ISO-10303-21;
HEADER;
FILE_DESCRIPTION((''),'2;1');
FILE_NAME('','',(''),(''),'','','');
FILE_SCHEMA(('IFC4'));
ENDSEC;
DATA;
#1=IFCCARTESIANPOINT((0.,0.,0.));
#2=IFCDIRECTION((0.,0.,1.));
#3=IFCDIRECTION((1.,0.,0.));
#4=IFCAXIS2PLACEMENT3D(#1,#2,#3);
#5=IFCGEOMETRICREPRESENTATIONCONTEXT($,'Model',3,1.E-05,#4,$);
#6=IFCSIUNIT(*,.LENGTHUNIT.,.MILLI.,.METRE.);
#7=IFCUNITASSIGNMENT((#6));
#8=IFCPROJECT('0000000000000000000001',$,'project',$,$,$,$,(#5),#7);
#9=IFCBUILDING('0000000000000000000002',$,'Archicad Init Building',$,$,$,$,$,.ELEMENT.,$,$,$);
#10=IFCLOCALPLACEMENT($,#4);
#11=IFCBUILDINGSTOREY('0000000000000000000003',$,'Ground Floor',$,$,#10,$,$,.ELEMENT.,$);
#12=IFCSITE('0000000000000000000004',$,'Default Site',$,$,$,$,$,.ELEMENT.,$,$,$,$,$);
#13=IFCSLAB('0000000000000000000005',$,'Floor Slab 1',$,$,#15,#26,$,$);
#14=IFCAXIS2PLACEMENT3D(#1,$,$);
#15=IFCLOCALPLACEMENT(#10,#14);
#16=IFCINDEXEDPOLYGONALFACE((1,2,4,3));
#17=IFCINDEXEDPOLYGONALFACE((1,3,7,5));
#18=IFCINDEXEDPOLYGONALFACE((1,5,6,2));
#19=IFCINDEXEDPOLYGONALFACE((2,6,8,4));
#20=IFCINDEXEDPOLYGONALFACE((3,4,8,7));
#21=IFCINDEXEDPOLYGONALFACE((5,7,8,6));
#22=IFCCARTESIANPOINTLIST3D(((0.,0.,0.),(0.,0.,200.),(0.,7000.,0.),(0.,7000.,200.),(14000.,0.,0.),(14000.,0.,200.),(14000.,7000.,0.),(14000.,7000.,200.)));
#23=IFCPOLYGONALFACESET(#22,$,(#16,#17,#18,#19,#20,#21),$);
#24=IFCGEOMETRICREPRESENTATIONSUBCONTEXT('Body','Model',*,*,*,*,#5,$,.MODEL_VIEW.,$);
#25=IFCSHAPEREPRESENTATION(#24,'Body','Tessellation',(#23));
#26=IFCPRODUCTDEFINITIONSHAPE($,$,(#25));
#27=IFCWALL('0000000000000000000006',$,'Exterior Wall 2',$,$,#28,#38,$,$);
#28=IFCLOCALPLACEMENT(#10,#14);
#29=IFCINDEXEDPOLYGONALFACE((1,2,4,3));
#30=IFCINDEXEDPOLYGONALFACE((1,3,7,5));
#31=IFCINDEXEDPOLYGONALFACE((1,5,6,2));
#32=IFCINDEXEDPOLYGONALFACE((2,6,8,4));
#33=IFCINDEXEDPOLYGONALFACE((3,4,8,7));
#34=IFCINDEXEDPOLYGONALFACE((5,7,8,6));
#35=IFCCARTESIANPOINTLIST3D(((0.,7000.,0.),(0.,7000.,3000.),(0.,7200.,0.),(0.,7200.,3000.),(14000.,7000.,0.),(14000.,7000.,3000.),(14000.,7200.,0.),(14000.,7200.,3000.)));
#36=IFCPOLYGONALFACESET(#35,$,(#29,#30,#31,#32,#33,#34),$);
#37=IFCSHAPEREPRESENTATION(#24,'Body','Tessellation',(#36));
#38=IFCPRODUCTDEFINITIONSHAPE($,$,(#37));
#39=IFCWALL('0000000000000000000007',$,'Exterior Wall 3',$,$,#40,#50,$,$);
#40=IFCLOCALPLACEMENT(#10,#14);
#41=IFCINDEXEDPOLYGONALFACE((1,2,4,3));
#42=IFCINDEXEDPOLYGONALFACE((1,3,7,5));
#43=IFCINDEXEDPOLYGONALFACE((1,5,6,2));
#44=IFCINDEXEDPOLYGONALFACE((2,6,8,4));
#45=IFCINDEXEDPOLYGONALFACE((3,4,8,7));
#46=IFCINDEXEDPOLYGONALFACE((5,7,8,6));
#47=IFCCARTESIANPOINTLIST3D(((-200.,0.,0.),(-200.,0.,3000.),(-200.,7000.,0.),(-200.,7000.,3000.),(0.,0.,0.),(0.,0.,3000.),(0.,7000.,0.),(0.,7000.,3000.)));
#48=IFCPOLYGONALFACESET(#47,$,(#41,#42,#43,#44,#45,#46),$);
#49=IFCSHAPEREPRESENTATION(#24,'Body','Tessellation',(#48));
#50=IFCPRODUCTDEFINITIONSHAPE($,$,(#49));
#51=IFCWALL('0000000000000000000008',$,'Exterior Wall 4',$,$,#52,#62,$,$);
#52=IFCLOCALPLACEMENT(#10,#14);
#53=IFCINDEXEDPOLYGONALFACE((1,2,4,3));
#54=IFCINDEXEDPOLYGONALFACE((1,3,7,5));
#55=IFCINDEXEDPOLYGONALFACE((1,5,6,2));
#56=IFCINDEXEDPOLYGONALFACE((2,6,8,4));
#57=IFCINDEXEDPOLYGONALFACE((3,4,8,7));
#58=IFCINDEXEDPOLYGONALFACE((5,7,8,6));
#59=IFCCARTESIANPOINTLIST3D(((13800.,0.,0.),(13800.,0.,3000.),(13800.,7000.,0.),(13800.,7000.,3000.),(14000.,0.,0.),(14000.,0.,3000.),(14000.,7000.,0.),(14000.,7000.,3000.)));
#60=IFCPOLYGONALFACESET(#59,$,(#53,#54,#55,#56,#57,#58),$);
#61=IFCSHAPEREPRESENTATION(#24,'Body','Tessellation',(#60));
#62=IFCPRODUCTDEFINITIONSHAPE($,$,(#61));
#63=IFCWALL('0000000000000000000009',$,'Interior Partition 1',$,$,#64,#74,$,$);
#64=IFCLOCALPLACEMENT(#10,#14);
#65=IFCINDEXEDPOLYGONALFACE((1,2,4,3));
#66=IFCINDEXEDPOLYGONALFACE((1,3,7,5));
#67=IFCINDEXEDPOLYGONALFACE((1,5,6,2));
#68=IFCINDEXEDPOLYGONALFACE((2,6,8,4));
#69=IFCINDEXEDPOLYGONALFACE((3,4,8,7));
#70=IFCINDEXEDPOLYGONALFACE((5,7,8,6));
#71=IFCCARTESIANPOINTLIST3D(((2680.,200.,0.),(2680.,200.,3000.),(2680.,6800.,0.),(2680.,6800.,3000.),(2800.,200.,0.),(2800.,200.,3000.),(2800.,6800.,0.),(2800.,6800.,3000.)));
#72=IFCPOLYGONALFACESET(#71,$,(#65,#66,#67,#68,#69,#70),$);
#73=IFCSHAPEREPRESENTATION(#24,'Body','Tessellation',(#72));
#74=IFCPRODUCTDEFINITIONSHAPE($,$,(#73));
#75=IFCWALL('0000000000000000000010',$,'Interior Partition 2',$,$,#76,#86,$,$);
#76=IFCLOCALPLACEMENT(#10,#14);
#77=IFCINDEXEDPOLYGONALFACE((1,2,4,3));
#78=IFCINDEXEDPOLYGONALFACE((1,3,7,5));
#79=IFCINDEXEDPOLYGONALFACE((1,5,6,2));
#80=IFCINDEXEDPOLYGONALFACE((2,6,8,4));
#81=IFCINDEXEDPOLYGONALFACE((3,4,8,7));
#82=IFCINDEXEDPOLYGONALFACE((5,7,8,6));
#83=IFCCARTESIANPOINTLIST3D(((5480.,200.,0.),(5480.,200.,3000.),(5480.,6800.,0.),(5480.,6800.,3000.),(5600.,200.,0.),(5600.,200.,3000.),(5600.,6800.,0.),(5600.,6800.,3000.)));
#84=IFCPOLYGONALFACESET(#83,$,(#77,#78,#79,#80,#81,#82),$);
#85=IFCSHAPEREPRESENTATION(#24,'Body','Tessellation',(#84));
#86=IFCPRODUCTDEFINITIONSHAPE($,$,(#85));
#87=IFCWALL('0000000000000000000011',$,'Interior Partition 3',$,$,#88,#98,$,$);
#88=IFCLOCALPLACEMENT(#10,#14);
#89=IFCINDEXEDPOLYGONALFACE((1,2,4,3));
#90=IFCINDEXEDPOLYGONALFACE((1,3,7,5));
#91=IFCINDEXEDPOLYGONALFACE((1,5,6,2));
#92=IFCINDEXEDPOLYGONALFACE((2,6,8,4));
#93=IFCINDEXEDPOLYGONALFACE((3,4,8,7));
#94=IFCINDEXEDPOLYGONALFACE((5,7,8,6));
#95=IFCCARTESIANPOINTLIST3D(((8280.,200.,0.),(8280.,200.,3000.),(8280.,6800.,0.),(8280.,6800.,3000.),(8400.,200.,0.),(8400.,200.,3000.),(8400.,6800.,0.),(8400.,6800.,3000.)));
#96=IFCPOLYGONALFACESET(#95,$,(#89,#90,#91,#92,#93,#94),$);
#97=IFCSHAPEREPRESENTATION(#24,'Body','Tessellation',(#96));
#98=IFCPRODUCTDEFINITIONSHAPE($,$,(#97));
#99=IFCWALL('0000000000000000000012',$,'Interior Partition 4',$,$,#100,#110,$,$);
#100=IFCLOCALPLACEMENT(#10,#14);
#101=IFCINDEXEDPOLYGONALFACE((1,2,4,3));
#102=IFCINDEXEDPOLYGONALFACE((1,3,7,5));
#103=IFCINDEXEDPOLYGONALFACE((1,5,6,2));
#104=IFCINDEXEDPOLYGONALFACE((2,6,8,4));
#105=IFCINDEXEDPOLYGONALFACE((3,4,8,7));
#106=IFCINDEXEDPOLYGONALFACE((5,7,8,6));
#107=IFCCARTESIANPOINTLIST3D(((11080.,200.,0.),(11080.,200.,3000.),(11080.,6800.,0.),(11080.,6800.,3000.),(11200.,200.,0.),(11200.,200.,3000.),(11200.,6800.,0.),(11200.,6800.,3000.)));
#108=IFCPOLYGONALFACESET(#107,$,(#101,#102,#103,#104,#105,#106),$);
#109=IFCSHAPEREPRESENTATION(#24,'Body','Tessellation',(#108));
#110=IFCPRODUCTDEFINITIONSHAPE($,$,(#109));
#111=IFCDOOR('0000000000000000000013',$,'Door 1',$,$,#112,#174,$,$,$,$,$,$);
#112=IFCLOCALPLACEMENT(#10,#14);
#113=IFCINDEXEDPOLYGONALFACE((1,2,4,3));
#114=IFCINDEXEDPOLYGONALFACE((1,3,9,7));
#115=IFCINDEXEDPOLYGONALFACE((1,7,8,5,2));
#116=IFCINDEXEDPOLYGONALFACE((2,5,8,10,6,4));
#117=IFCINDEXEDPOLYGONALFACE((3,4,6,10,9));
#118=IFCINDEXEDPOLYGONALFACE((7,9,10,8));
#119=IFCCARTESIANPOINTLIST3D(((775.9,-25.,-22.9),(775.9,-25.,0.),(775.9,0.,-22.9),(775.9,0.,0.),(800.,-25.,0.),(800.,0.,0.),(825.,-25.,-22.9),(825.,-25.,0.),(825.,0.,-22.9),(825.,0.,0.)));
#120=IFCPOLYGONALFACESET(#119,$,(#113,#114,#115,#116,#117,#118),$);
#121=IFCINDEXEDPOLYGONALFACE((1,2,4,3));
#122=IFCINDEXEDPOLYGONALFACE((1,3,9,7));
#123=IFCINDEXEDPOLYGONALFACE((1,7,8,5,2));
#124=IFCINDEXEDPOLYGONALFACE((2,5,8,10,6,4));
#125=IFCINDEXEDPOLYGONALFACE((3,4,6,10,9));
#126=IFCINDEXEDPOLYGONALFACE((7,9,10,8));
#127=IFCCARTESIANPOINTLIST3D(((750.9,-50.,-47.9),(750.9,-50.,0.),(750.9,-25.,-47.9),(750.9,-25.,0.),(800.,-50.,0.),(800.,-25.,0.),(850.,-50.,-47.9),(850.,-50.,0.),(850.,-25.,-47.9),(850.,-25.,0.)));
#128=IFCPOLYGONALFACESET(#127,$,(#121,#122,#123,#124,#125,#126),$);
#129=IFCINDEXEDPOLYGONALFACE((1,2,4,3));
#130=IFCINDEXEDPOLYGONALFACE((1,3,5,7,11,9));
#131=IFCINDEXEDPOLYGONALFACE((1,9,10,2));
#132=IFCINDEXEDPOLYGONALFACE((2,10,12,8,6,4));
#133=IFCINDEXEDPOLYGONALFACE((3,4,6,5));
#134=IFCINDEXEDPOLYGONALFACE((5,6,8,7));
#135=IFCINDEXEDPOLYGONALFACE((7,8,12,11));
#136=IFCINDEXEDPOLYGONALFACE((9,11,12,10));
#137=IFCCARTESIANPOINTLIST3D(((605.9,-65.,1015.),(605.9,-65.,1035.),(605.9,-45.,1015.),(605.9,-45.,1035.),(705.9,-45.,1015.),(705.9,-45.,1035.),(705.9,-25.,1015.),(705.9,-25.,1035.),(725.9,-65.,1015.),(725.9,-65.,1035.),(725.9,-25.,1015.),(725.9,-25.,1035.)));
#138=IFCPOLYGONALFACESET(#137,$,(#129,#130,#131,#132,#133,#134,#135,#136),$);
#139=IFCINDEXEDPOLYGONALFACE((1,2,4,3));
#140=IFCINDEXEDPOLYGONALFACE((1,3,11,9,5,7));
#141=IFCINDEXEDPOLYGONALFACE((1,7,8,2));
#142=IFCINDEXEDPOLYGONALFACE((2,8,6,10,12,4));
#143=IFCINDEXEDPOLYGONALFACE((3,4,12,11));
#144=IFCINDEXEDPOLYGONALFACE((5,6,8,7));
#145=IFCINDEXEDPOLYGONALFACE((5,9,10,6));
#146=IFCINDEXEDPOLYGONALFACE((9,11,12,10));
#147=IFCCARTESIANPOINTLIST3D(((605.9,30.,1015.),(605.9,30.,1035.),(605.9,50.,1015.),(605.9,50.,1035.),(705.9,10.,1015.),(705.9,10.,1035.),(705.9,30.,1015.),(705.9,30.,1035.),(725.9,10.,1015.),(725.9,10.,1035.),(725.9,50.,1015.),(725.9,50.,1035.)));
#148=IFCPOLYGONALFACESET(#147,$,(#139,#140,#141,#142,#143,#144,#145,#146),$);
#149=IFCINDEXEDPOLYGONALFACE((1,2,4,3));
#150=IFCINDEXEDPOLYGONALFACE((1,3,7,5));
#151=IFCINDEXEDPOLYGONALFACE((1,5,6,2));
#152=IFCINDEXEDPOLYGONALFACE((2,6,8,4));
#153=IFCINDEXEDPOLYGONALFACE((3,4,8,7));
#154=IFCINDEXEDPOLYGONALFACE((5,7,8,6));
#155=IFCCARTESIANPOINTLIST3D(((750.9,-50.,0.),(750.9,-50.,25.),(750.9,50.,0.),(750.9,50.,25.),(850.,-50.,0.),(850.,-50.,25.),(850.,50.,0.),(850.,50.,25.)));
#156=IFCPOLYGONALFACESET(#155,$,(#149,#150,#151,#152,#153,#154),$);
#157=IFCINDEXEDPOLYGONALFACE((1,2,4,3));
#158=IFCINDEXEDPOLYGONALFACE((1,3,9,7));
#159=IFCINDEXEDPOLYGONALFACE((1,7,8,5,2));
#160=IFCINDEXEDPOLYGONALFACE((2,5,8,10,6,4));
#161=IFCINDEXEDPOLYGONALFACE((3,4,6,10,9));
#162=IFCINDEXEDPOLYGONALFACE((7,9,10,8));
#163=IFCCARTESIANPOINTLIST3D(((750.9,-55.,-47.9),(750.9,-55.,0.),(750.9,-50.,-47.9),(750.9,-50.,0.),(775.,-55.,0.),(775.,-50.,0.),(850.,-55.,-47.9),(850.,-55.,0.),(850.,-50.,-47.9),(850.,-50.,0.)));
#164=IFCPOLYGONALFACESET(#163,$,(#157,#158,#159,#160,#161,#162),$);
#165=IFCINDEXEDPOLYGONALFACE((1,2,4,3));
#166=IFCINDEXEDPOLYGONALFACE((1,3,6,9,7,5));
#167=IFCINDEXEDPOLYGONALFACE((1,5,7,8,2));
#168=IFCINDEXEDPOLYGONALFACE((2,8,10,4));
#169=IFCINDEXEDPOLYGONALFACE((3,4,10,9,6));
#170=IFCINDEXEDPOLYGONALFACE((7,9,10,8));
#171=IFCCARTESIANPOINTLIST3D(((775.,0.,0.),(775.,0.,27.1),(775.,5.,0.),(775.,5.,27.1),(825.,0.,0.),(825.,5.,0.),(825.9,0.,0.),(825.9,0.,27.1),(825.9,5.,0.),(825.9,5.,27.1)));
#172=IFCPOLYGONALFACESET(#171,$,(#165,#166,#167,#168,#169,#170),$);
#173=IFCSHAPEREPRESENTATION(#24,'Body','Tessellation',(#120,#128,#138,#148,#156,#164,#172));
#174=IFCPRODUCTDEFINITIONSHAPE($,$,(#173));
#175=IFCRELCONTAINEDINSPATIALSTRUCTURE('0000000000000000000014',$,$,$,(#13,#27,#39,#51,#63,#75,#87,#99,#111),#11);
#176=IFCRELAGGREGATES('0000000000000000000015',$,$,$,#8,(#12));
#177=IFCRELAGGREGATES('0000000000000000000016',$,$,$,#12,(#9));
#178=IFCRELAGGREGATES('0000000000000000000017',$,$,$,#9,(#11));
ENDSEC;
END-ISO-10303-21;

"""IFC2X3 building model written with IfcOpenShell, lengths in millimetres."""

from ifc_helpers import new_model, si_unit, frame, origin_with_axes, place, context, subcontext, project, spatial, polyline, outline, extrude, element, save


model = new_model("IFC2X3")

# Units and contexts
model_context = context("Model", 3, precision=1e-05, world=origin_with_axes())
body_context = subcontext(model_context, "Body", "Model", "MODEL_VIEW")
ifc_project = project(units=[si_unit("LENGTHUNIT", "METRE", prefix="MILLI")], contexts=[model_context])

# Site, building, storey
site = spatial("IfcSite", under=ifc_project, Name="Default Site", CompositionType="ELEMENT")
building = spatial("IfcBuilding", under=site, Name="Archicad Init Building", CompositionType="ELEMENT")
storey_placement = place(None, origin_with_axes())
storey = spatial("IfcBuildingStorey", under=building, at=storey_placement, Name="Ground Floor", CompositionType="ELEMENT")

# Slab
slab_placement = place(storey_placement, origin_with_axes())
element("IfcSlab", 1, at=slab_placement, inside=storey, Name="Floor Slab 1", context=body_context, shape_type="SweptSolid", body=[
    extrude(outline(polyline([(0.0, 0.0), (14000.0, 0.0), (14000.0, 7000.0), (0.0, 7000.0), (0.0, 0.0)])), origin_with_axes(), (0.0, 0.0, 1.0), 200.0),
])

# Walls
wall_placement = place(storey_placement, frame((0.0, 7000.0, 0.0), z_axis=(0.0, 0.0, 1.0), x_axis=(1.0, 0.0, 0.0)))
element("IfcWall", 2, at=wall_placement, inside=storey, Name="Exterior Wall 2", context=body_context, shape_type="SweptSolid", body=[
    extrude(outline(polyline([(0.0, 0.0), (0.0, 200.0), (14000.0, 200.0), (14000.0, 0.0), (0.0, 0.0)])), origin_with_axes(), (0.0, 0.0, 1.0), 3000.0),
])
for number, where, z_axis, x_axis, name in (
    (3, (0.0, 0.0, 0.0), (0.0, 0.0, 1.0), (0.0, 1.0, 0.0), "Exterior Wall 3"),
    (4, (14000.0, 0.0, 0.0), (0.0, 0.0, 1.0), (0.0, 1.0, 0.0), "Exterior Wall 4"),
):
    element("IfcWall", number, at=place(storey_placement, frame(where, z_axis=z_axis, x_axis=x_axis)), inside=storey, Name=name, context=body_context, shape_type="SweptSolid", body=[
        extrude(outline(polyline([(0.0, 0.0), (0.0, 200.0), (7000.0, 200.0), (7000.0, 0.0), (0.0, 0.0)])), origin_with_axes(), (0.0, 0.0, 1.0), 3000.0),
    ])
for number, where, z_axis, x_axis, name in (
    (5, (2800.0, 200.0, 0.0), (0.0, 0.0, 1.0), (0.0, 1.0, 0.0), "Interior Partition 1"),
    (6, (5600.0, 200.0, 0.0), (0.0, 0.0, 1.0), (0.0, 1.0, 0.0), "Interior Partition 2"),
    (7, (8400.0, 200.0, 0.0), (0.0, 0.0, 1.0), (0.0, 1.0, 0.0), "Interior Partition 3"),
    (8, (11200.0, 200.0, 0.0), (0.0, 0.0, 1.0), (0.0, 1.0, 0.0), "Interior Partition 4"),
):
    element("IfcWall", number, at=place(storey_placement, frame(where, z_axis=z_axis, x_axis=x_axis)), inside=storey, Name=name, context=body_context, shape_type="SweptSolid", body=[
        extrude(outline(polyline([(0.0, 0.0), (0.0, 120.0), (6600.0, 120.0), (6600.0, 0.0), (0.0, 0.0)])), origin_with_axes(), (0.0, 0.0, 1.0), 3000.0),
    ])

# Door
door_1_placement = place(storey_placement, frame((800.0, -50.0, 0.0), z_axis=(0.0, 0.0, 1.0), x_axis=(1.0, 0.0, 0.0)))
element("IfcDoor", 9, at=door_1_placement, inside=storey, Name="Door 1", context=body_context, shape_type="SweptSolid", body=[
    extrude(outline(polyline([(0.0, 0.0), (0.0, 2.1), (0.9, 2.1), (0.9, 0.0), (-24.1, 0.0), (-24.1, -22.9), (25.0, -22.9), (25.0, 0.0), (0.0, 0.0)])), frame((0.0, 25.0, 0.0), z_axis=(0.0, -1.0, 0.0), x_axis=(1.0, 0.0, 0.0)), (0.0, 0.0, -1.0), 25.0),
    extrude(outline(polyline([(0.0, 0.0), (0.0, 2.1), (0.9, 2.1), (0.9, 0.0), (-49.1, 0.0), (-49.1, -47.9), (50.0, -47.9), (50.0, 0.0), (0.0, 0.0)])), frame((0.0, 0.0, 0.0), z_axis=(0.0, -1.0, 0.0), x_axis=(1.0, 0.0, 0.0)), (0.0, 0.0, -1.0), 25.0),
    extrude(outline(polyline([(0.0, 0.0), (-49.1, 0.0), (-49.1, 35.0), (0.0, 35.0), (0.0, 0.0)])), frame((25.0, 25.0, 25.0), z_axis=(0.0, 0.0, 1.0), x_axis=(1.0, 0.0, 0.0)), (0.0, 0.0, 1.0), -47.9),
    extrude(outline(polyline([(0.0, 0.0), (0.0, -40.0), (-120.0, -40.0), (-120.0, -20.0), (-20.0, -20.0), (-20.0, 0.0), (0.0, 0.0)])), frame((-74.1, 25.0, 1015.0), z_axis=(0.0, 0.0, 1.0), x_axis=(1.0, 0.0, 0.0)), (0.0, 0.0, 1.0), 20.0),
    extrude(outline(polyline([(0.0, 0.0), (0.0, 40.0), (-120.0, 40.0), (-120.0, 20.0), (-20.0, 20.0), (-20.0, 0.0), (0.0, 0.0)])), frame((-74.1, 60.0, 1015.0), z_axis=(0.0, 0.0, 1.0), x_axis=(1.0, 0.0, 0.0)), (0.0, 0.0, 1.0), 20.0),
    extrude(outline(polyline([(0.0, 0.0), (-99.1, 0.0), (-99.1, 100.0), (0.0, 100.0), (0.0, 0.0)])), frame((50.0, 0.0, 0.0), z_axis=(0.0, 0.0, 1.0), x_axis=(1.0, 0.0, 0.0)), (0.0, 0.0, 1.0), 25.0),
    extrude(outline(polyline([(0.0, 0.0), (0.0, 27.1), (50.9, 27.1), (50.9, 0.0), (-24.1, 0.0), (-24.1, -47.9), (75.0, -47.9), (75.0, 0.0), (0.0, 0.0)])), frame((-25.0, -5.0, 0.0), z_axis=(0.0, -1.0, 0.0), x_axis=(1.0, 0.0, 0.0)), (0.0, 0.0, -1.0), 5.0),
    extrude(outline(polyline([(0.0, 0.0), (0.0, 27.1), (50.9, 27.1), (50.9, 0.0), (0.9, 0.0), (0.9, -22.9), (50.0, -22.9), (50.0, 0.0), (0.0, 0.0)])), frame((-25.0, 50.0, 0.0), z_axis=(0.0, -1.0, 0.0), x_axis=(1.0, 0.0, 0.0)), (0.0, 0.0, -1.0), 5.0),
])

save(model, "model.ifc")
